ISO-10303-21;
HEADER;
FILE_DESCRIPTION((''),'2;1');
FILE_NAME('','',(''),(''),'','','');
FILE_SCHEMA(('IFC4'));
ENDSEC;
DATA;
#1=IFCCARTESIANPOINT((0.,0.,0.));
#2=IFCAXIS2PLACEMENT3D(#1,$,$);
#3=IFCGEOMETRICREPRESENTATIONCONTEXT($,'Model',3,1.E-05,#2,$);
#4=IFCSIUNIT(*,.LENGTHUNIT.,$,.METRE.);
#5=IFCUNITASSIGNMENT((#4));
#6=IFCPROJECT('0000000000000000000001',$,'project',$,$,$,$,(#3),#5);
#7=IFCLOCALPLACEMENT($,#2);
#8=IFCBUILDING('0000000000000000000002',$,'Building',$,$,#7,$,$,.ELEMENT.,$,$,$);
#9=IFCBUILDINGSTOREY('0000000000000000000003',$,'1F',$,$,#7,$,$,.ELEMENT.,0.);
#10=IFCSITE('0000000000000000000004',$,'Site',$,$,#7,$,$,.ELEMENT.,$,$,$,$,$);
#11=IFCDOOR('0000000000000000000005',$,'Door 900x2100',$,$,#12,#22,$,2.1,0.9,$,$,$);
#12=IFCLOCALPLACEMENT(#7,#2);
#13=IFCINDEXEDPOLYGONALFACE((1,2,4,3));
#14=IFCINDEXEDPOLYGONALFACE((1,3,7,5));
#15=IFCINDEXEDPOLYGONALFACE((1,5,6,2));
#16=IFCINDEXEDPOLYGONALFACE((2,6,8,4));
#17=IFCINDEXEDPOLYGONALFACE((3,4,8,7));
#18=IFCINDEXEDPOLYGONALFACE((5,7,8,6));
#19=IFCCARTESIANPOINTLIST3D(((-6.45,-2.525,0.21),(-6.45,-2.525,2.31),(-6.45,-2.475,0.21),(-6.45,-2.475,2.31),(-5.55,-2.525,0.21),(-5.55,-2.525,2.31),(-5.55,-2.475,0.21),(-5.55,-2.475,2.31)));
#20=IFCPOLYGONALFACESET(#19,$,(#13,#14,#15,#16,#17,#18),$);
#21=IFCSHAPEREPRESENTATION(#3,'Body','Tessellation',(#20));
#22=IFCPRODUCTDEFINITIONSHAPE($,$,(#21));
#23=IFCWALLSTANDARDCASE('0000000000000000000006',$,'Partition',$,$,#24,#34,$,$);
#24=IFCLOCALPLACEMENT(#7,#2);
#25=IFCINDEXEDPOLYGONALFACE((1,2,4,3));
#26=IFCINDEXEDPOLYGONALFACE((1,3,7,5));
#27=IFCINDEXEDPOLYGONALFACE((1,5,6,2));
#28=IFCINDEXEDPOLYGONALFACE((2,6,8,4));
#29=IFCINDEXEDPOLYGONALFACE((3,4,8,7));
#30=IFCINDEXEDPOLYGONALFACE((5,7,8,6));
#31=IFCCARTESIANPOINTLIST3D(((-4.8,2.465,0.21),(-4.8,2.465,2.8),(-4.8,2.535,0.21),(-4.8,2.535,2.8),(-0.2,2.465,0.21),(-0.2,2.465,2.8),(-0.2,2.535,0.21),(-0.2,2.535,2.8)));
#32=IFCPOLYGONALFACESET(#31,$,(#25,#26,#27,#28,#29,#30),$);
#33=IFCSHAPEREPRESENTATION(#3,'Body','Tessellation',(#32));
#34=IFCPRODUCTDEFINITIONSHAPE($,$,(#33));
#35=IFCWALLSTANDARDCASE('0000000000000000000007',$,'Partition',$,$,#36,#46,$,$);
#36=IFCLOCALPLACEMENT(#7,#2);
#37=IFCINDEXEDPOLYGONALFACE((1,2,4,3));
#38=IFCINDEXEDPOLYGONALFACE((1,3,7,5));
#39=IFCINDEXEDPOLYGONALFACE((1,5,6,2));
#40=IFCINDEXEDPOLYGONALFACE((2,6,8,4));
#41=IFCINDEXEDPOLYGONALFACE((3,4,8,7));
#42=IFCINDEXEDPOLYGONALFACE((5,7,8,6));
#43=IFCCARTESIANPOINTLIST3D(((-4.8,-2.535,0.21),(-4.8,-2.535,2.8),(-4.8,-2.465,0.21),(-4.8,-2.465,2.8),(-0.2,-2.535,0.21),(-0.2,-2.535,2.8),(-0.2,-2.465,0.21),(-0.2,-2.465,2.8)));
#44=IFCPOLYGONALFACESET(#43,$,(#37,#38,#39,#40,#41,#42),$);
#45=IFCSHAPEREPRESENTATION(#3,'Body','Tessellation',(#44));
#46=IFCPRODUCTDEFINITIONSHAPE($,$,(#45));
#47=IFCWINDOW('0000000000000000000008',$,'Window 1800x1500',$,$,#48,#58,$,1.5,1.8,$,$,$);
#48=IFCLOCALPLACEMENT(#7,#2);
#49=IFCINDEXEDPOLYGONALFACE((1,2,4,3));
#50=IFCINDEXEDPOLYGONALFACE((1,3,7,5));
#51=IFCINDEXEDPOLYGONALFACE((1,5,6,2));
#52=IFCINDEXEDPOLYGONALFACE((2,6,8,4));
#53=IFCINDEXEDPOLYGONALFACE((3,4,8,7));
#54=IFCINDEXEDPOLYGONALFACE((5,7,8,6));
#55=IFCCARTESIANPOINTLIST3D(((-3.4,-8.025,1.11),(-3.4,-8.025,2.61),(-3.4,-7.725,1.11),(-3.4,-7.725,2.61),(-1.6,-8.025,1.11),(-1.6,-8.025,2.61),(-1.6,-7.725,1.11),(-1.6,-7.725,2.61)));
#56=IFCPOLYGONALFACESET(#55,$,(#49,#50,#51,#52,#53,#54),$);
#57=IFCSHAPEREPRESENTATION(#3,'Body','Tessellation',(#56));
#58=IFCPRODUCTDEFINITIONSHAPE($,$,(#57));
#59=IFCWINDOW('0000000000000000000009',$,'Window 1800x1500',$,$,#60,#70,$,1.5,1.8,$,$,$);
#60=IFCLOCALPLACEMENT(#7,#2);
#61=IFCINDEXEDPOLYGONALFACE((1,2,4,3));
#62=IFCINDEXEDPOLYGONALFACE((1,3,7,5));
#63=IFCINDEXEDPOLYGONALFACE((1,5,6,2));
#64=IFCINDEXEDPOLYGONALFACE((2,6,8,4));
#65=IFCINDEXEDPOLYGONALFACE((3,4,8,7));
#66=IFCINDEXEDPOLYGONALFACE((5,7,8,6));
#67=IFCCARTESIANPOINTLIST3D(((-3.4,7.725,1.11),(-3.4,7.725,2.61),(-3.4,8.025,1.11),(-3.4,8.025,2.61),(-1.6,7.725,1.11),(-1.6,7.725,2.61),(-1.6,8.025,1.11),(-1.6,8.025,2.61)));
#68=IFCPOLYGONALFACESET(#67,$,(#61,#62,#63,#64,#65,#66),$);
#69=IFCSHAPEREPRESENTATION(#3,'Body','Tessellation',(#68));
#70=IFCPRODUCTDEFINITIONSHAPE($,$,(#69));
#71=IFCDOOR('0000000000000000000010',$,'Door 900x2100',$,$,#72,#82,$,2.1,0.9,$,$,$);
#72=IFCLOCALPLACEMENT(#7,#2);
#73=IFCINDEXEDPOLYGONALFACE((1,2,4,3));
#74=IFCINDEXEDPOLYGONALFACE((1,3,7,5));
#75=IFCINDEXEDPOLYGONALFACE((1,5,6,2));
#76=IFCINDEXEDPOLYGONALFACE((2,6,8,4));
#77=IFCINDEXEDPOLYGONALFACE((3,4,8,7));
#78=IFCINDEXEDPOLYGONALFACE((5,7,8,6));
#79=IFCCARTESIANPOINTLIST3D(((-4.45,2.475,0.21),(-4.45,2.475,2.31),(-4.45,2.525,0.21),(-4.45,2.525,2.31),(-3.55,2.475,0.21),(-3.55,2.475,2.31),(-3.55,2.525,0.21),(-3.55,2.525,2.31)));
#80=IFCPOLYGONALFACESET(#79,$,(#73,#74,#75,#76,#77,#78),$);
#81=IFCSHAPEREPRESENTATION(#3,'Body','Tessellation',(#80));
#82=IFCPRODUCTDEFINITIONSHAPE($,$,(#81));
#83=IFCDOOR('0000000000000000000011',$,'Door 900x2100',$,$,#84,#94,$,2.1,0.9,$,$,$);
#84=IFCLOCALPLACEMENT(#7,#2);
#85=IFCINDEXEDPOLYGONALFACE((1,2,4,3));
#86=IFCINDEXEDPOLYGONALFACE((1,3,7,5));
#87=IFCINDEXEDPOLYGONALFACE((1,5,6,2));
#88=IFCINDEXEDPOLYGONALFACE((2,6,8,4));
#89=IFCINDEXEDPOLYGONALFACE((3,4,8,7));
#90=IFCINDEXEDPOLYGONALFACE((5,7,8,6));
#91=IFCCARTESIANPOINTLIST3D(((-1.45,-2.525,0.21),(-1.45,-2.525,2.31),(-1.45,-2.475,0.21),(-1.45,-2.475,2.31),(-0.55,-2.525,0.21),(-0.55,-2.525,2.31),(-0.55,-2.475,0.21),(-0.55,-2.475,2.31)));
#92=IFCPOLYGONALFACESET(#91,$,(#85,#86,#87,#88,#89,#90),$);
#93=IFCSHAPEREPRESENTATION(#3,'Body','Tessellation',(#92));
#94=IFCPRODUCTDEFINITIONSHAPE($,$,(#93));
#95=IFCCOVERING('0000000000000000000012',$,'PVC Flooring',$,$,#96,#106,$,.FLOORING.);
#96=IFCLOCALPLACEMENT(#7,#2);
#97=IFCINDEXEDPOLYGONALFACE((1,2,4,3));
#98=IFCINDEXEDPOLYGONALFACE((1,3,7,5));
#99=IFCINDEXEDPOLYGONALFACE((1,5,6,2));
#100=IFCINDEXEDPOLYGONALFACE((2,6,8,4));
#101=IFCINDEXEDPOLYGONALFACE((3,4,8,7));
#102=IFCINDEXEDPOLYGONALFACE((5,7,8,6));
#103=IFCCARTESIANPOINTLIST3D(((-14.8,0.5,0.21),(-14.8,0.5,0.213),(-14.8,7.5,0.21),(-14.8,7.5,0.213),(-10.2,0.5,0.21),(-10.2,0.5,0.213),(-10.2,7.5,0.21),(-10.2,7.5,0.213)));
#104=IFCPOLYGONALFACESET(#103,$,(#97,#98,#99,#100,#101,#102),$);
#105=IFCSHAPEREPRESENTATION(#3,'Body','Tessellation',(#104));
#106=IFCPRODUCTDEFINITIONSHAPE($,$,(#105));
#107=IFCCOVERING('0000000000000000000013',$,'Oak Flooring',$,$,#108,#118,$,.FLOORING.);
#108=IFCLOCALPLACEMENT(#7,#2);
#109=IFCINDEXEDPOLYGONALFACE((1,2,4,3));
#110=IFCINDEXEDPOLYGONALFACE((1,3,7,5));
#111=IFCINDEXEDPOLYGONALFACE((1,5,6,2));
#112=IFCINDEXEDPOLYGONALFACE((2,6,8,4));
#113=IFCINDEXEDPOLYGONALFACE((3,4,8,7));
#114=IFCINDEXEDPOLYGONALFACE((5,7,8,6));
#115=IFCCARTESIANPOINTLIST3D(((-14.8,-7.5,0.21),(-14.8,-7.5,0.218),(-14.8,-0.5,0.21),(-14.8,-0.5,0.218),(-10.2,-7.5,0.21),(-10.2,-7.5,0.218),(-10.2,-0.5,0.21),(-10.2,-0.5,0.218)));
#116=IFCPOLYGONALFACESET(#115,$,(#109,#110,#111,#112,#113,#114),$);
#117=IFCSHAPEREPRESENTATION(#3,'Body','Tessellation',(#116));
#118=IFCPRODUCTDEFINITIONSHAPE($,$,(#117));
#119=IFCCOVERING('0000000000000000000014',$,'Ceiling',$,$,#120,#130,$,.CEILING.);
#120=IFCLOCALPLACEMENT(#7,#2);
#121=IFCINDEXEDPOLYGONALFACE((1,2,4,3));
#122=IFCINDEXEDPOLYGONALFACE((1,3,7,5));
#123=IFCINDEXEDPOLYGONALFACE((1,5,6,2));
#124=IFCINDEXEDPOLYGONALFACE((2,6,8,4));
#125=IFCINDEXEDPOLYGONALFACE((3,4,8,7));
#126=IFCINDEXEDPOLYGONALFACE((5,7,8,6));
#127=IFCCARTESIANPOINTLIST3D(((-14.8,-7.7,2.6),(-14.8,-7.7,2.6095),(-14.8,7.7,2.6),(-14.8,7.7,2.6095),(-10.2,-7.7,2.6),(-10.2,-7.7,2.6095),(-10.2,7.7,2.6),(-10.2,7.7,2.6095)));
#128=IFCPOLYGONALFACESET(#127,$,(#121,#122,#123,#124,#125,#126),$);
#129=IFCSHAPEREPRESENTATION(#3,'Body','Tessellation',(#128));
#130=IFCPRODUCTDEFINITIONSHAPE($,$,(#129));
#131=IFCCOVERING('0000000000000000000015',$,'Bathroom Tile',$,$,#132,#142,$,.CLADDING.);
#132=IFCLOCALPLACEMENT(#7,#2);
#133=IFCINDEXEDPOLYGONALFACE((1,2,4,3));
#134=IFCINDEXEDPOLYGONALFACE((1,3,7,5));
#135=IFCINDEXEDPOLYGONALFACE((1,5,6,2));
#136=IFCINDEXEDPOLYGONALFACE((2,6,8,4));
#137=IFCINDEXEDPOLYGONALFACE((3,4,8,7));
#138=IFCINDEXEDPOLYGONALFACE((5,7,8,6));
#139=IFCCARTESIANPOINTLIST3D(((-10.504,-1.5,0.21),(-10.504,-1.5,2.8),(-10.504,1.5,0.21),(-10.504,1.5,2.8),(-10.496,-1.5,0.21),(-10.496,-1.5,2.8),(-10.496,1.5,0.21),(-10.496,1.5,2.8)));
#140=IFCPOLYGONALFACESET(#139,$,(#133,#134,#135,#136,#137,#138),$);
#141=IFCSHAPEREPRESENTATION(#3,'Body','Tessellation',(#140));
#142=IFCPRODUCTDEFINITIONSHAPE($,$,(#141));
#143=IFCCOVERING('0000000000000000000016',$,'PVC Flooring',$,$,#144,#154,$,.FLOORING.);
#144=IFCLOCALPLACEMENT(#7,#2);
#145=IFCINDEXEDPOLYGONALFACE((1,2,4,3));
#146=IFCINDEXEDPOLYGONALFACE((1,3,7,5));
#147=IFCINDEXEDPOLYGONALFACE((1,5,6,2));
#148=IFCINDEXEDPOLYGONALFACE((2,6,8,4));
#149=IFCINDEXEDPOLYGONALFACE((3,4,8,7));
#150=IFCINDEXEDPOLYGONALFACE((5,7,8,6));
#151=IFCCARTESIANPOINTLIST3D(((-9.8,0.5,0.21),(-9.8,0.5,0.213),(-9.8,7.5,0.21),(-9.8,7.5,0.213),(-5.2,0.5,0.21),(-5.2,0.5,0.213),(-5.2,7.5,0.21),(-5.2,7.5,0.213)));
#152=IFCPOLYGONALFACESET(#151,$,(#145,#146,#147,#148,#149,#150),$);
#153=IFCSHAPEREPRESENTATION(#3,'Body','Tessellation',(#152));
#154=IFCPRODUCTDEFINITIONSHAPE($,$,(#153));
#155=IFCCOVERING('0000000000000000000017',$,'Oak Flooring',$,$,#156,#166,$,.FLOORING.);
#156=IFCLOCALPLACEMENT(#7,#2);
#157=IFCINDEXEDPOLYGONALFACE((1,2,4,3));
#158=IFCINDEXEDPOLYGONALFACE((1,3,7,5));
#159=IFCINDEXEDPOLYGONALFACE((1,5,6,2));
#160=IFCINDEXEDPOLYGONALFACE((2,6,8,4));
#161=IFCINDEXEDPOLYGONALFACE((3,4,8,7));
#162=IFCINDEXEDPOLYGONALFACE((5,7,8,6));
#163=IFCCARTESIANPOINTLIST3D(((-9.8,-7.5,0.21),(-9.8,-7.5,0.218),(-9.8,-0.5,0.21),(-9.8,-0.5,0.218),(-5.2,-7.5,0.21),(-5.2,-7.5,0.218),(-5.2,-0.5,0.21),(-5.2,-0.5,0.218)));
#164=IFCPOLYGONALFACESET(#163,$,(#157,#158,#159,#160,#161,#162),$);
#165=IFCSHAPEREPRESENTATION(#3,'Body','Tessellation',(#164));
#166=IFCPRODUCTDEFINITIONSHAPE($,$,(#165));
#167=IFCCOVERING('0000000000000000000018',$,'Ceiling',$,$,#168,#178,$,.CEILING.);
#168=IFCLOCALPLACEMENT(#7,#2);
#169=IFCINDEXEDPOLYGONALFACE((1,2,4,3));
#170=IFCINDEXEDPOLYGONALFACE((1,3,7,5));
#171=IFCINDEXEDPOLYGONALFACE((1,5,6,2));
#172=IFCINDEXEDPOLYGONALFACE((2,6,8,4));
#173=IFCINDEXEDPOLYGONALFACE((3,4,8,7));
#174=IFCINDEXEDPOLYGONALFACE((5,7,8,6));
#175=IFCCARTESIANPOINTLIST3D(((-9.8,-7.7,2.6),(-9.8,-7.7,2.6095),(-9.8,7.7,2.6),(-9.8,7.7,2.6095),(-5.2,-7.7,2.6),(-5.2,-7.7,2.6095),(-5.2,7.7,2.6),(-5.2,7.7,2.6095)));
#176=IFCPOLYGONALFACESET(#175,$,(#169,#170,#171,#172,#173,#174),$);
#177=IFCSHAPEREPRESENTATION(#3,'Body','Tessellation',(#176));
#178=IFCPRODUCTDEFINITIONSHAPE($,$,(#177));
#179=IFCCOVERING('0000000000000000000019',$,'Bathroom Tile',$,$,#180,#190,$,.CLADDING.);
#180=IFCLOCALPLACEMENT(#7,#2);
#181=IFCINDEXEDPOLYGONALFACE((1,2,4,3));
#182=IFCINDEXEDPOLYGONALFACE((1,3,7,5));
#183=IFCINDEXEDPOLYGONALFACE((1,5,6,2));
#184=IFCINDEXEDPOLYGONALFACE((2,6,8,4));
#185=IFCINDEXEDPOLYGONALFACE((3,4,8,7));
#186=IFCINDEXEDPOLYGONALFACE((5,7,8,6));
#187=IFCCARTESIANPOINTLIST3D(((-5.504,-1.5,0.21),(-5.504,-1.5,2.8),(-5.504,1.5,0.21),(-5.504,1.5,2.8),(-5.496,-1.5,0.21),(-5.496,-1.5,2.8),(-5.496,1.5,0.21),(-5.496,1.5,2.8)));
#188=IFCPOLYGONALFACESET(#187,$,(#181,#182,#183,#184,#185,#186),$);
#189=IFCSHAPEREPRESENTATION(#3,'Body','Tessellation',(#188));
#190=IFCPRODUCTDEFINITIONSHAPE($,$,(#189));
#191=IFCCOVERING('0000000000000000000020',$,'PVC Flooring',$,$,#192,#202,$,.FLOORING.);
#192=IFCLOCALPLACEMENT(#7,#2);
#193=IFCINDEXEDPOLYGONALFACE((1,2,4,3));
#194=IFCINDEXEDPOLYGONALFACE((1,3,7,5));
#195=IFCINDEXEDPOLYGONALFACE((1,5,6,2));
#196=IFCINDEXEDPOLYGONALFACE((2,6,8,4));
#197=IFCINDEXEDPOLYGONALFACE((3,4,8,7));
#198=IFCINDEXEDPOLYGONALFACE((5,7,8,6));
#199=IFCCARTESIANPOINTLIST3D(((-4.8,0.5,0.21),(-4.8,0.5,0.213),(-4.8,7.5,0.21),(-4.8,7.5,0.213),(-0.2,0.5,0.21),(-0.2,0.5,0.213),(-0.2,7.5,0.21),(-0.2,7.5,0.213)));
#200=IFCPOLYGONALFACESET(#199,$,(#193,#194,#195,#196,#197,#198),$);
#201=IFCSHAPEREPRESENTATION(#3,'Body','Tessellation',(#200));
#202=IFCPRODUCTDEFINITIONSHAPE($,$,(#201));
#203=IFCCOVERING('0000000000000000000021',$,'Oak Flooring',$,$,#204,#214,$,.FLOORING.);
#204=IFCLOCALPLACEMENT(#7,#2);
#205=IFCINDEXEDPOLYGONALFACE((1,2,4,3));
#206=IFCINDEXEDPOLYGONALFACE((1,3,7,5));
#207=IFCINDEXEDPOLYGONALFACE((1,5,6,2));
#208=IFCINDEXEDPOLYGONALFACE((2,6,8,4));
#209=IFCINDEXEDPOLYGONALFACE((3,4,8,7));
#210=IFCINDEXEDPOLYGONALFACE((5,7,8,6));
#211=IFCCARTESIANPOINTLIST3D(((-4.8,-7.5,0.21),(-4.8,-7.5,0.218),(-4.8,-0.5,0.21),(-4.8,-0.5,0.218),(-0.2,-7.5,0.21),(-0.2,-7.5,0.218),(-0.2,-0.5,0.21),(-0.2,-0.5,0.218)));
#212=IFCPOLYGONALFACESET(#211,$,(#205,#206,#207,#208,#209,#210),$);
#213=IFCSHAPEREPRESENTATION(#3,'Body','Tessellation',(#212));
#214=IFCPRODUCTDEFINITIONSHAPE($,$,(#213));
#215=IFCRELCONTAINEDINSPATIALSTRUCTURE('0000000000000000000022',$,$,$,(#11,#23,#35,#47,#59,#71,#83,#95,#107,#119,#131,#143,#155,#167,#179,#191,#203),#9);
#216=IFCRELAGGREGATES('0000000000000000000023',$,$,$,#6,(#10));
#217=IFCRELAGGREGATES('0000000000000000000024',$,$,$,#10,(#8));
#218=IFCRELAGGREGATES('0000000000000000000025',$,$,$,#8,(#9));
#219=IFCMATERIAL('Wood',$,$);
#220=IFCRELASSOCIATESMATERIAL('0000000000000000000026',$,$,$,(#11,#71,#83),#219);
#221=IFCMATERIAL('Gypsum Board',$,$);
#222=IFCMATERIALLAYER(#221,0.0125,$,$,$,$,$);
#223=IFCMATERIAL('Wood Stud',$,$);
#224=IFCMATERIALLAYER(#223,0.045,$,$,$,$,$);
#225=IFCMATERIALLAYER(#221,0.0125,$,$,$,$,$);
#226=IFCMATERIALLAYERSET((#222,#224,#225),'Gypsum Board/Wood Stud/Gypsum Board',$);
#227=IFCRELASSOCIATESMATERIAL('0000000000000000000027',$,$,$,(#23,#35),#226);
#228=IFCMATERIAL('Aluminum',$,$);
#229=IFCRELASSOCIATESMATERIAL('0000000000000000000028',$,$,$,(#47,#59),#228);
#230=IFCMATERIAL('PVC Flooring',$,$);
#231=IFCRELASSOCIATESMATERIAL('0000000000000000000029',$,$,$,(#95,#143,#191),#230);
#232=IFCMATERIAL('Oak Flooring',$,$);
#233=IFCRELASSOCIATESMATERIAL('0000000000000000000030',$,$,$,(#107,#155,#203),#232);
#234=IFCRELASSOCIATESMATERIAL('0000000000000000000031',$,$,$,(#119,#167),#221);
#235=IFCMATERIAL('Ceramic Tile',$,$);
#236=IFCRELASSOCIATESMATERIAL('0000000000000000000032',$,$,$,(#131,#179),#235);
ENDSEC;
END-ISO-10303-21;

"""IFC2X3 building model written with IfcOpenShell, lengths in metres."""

from ifc_helpers import new_model, si_unit, frame, origin, origin_2d, place, context, project, spatial, rectangle, extrude, material, layer, layer_set, layer_usage, element, save


model = new_model("IFC2X3")

# Units and contexts
model_context = context("Model", 3, precision=1e-05, world=origin())
ifc_project = project(units=[si_unit("LENGTHUNIT", "METRE")], contexts=[model_context])

# Site, building, storey
placement = place(None, origin())
site = spatial("IfcSite", under=ifc_project, at=placement, Name="Site", CompositionType="ELEMENT")
building = spatial("IfcBuilding", under=site, at=placement, Name="Building", CompositionType="ELEMENT")
storey = spatial("IfcBuildingStorey", under=building, at=placement, Name="1F", CompositionType="ELEMENT", Elevation=0.0)

# Shared definitions
ifc_material_1 = material(Name="Gypsum Board")
ifc_layer_1 = layer(ifc_material_1, 0.0125)
ifc_material_2 = material(Name="Wood Stud")
ifc_layer_2 = layer(ifc_material_2, 0.045)
ifc_layer_3 = layer(ifc_material_1, 0.0125)
ifc_layer_set_1 = layer_set([ifc_layer_1, ifc_layer_2, ifc_layer_3], Name="Gypsum Board/Wood Stud/Gypsum Board")
ifc_layer_usage_1 = layer_usage(ifc_layer_set_1, "AXIS2", "POSITIVE", 0.0)

# Shared definitions
ifc_material_3 = material(Name="Aluminum")

# Shared definitions
ifc_material_4 = material(Name="Wood")

# Door
for number, where, name in (
    (1, (-6.0, -2.5, 0.21), "Door 900x2100"),
):
    element("IfcDoor", number, at=place(None, frame(where)), inside=storey, material=ifc_material_4, Name=name, OverallHeight=2.1, OverallWidth=0.9, context=model_context, shape_type="SweptSolid", body=[
        extrude(rectangle(XDim=0.9, YDim=0.05, at=origin_2d()), origin(), (0.0, 0.0, 1.0), 2.1),
    ])

# Walls
for number, where, name in (
    (2, (-2.5, 2.5, 0.21), "Partition"),
    (3, (-2.5, -2.5, 0.21), "Partition"),
):
    element("IfcWallStandardCase", number, at=place(None, frame(where)), inside=storey, material=ifc_layer_usage_1, Name=name, context=model_context, shape_type="SweptSolid", body=[
        extrude(rectangle(XDim=4.6, YDim=0.07, at=origin_2d()), origin(), (0.0, 0.0, 1.0), 2.59),
    ])

# Windows
for number, where, name in (
    (4, (-2.5, -7.875, 1.11), "Window 1800x1500"),
    (5, (-2.5, 7.875, 1.11), "Window 1800x1500"),
):
    element("IfcWindow", number, at=place(None, frame(where)), inside=storey, material=ifc_material_3, Name=name, OverallHeight=1.5, OverallWidth=1.8, context=model_context, shape_type="SweptSolid", body=[
        extrude(rectangle(XDim=1.8, YDim=0.3, at=origin_2d()), origin(), (0.0, 0.0, 1.0), 1.5),
    ])

# Doors
for number, where, name in (
    (6, (-4.0, 2.5, 0.21), "Door 900x2100"),
    (7, (-1.0, -2.5, 0.21), "Door 900x2100"),
):
    element("IfcDoor", number, at=place(None, frame(where)), inside=storey, material=ifc_material_4, Name=name, OverallHeight=2.1, OverallWidth=0.9, context=model_context, shape_type="SweptSolid", body=[
        extrude(rectangle(XDim=0.9, YDim=0.05, at=origin_2d()), origin(), (0.0, 0.0, 1.0), 2.1),
    ])

# Coverings
ifc_material_5 = material(Name="PVC Flooring")
covering_1_placement = place(None, frame((-12.5, 4.0, 0.21)))
element("IfcCovering", 8, at=covering_1_placement, inside=storey, material=ifc_material_5, Name="PVC Flooring", PredefinedType="FLOORING", context=model_context, shape_type="SweptSolid", body=[
    extrude(rectangle(XDim=4.6, YDim=7.0, at=origin_2d()), origin(), (0.0, 0.0, 1.0), 0.003),
])
ifc_material_6 = material(Name="Oak Flooring")
covering_2_placement = place(None, frame((-12.5, -4.0, 0.21)))
element("IfcCovering", 9, at=covering_2_placement, inside=storey, material=ifc_material_6, Name="Oak Flooring", PredefinedType="FLOORING", context=model_context, shape_type="SweptSolid", body=[
    extrude(rectangle(XDim=4.6, YDim=7.0, at=origin_2d()), origin(), (0.0, 0.0, 1.0), 0.008),
])
covering_3_placement = place(None, frame((-12.5, 0.0, 2.6)))
element("IfcCovering", 10, at=covering_3_placement, inside=storey, material=ifc_material_1, Name="Ceiling", PredefinedType="CEILING", context=model_context, shape_type="SweptSolid", body=[
    extrude(rectangle(XDim=4.6, YDim=15.4, at=origin_2d()), origin(), (0.0, 0.0, 1.0), 0.0095),
])
ifc_material_7 = material(Name="Ceramic Tile")
covering_4_placement = place(None, frame((-10.5, 0.0, 0.21)))
element("IfcCovering", 11, at=covering_4_placement, inside=storey, material=ifc_material_7, Name="Bathroom Tile", PredefinedType="CLADDING", context=model_context, shape_type="SweptSolid", body=[
    extrude(rectangle(XDim=0.008, YDim=3.0, at=origin_2d()), origin(), (0.0, 0.0, 1.0), 2.59),
])
covering_5_placement = place(None, frame((-7.5, 4.0, 0.21)))
element("IfcCovering", 12, at=covering_5_placement, inside=storey, material=ifc_material_5, Name="PVC Flooring", PredefinedType="FLOORING", context=model_context, shape_type="SweptSolid", body=[
    extrude(rectangle(XDim=4.6, YDim=7.0, at=origin_2d()), origin(), (0.0, 0.0, 1.0), 0.003),
])
covering_6_placement = place(None, frame((-7.5, -4.0, 0.21)))
element("IfcCovering", 13, at=covering_6_placement, inside=storey, material=ifc_material_6, Name="Oak Flooring", PredefinedType="FLOORING", context=model_context, shape_type="SweptSolid", body=[
    extrude(rectangle(XDim=4.6, YDim=7.0, at=origin_2d()), origin(), (0.0, 0.0, 1.0), 0.008),
])
covering_7_placement = place(None, frame((-7.5, 0.0, 2.6)))
element("IfcCovering", 14, at=covering_7_placement, inside=storey, material=ifc_material_1, Name="Ceiling", PredefinedType="CEILING", context=model_context, shape_type="SweptSolid", body=[
    extrude(rectangle(XDim=4.6, YDim=15.4, at=origin_2d()), origin(), (0.0, 0.0, 1.0), 0.0095),
])
covering_8_placement = place(None, frame((-5.5, 0.0, 0.21)))
element("IfcCovering", 15, at=covering_8_placement, inside=storey, material=ifc_material_7, Name="Bathroom Tile", PredefinedType="CLADDING", context=model_context, shape_type="SweptSolid", body=[
    extrude(rectangle(XDim=0.008, YDim=3.0, at=origin_2d()), origin(), (0.0, 0.0, 1.0), 2.59),
])
covering_9_placement = place(None, frame((-2.5, 4.0, 0.21)))
element("IfcCovering", 16, at=covering_9_placement, inside=storey, material=ifc_material_5, Name="PVC Flooring", PredefinedType="FLOORING", context=model_context, shape_type="SweptSolid", body=[
    extrude(rectangle(XDim=4.6, YDim=7.0, at=origin_2d()), origin(), (0.0, 0.0, 1.0), 0.003),
])
covering_10_placement = place(None, frame((-2.5, -4.0, 0.21)))
element("IfcCovering", 17, at=covering_10_placement, inside=storey, material=ifc_material_6, Name="Oak Flooring", PredefinedType="FLOORING", context=model_context, shape_type="SweptSolid", body=[
    extrude(rectangle(XDim=4.6, YDim=7.0, at=origin_2d()), origin(), (0.0, 0.0, 1.0), 0.008),
])

save(model, "model.ifc")
